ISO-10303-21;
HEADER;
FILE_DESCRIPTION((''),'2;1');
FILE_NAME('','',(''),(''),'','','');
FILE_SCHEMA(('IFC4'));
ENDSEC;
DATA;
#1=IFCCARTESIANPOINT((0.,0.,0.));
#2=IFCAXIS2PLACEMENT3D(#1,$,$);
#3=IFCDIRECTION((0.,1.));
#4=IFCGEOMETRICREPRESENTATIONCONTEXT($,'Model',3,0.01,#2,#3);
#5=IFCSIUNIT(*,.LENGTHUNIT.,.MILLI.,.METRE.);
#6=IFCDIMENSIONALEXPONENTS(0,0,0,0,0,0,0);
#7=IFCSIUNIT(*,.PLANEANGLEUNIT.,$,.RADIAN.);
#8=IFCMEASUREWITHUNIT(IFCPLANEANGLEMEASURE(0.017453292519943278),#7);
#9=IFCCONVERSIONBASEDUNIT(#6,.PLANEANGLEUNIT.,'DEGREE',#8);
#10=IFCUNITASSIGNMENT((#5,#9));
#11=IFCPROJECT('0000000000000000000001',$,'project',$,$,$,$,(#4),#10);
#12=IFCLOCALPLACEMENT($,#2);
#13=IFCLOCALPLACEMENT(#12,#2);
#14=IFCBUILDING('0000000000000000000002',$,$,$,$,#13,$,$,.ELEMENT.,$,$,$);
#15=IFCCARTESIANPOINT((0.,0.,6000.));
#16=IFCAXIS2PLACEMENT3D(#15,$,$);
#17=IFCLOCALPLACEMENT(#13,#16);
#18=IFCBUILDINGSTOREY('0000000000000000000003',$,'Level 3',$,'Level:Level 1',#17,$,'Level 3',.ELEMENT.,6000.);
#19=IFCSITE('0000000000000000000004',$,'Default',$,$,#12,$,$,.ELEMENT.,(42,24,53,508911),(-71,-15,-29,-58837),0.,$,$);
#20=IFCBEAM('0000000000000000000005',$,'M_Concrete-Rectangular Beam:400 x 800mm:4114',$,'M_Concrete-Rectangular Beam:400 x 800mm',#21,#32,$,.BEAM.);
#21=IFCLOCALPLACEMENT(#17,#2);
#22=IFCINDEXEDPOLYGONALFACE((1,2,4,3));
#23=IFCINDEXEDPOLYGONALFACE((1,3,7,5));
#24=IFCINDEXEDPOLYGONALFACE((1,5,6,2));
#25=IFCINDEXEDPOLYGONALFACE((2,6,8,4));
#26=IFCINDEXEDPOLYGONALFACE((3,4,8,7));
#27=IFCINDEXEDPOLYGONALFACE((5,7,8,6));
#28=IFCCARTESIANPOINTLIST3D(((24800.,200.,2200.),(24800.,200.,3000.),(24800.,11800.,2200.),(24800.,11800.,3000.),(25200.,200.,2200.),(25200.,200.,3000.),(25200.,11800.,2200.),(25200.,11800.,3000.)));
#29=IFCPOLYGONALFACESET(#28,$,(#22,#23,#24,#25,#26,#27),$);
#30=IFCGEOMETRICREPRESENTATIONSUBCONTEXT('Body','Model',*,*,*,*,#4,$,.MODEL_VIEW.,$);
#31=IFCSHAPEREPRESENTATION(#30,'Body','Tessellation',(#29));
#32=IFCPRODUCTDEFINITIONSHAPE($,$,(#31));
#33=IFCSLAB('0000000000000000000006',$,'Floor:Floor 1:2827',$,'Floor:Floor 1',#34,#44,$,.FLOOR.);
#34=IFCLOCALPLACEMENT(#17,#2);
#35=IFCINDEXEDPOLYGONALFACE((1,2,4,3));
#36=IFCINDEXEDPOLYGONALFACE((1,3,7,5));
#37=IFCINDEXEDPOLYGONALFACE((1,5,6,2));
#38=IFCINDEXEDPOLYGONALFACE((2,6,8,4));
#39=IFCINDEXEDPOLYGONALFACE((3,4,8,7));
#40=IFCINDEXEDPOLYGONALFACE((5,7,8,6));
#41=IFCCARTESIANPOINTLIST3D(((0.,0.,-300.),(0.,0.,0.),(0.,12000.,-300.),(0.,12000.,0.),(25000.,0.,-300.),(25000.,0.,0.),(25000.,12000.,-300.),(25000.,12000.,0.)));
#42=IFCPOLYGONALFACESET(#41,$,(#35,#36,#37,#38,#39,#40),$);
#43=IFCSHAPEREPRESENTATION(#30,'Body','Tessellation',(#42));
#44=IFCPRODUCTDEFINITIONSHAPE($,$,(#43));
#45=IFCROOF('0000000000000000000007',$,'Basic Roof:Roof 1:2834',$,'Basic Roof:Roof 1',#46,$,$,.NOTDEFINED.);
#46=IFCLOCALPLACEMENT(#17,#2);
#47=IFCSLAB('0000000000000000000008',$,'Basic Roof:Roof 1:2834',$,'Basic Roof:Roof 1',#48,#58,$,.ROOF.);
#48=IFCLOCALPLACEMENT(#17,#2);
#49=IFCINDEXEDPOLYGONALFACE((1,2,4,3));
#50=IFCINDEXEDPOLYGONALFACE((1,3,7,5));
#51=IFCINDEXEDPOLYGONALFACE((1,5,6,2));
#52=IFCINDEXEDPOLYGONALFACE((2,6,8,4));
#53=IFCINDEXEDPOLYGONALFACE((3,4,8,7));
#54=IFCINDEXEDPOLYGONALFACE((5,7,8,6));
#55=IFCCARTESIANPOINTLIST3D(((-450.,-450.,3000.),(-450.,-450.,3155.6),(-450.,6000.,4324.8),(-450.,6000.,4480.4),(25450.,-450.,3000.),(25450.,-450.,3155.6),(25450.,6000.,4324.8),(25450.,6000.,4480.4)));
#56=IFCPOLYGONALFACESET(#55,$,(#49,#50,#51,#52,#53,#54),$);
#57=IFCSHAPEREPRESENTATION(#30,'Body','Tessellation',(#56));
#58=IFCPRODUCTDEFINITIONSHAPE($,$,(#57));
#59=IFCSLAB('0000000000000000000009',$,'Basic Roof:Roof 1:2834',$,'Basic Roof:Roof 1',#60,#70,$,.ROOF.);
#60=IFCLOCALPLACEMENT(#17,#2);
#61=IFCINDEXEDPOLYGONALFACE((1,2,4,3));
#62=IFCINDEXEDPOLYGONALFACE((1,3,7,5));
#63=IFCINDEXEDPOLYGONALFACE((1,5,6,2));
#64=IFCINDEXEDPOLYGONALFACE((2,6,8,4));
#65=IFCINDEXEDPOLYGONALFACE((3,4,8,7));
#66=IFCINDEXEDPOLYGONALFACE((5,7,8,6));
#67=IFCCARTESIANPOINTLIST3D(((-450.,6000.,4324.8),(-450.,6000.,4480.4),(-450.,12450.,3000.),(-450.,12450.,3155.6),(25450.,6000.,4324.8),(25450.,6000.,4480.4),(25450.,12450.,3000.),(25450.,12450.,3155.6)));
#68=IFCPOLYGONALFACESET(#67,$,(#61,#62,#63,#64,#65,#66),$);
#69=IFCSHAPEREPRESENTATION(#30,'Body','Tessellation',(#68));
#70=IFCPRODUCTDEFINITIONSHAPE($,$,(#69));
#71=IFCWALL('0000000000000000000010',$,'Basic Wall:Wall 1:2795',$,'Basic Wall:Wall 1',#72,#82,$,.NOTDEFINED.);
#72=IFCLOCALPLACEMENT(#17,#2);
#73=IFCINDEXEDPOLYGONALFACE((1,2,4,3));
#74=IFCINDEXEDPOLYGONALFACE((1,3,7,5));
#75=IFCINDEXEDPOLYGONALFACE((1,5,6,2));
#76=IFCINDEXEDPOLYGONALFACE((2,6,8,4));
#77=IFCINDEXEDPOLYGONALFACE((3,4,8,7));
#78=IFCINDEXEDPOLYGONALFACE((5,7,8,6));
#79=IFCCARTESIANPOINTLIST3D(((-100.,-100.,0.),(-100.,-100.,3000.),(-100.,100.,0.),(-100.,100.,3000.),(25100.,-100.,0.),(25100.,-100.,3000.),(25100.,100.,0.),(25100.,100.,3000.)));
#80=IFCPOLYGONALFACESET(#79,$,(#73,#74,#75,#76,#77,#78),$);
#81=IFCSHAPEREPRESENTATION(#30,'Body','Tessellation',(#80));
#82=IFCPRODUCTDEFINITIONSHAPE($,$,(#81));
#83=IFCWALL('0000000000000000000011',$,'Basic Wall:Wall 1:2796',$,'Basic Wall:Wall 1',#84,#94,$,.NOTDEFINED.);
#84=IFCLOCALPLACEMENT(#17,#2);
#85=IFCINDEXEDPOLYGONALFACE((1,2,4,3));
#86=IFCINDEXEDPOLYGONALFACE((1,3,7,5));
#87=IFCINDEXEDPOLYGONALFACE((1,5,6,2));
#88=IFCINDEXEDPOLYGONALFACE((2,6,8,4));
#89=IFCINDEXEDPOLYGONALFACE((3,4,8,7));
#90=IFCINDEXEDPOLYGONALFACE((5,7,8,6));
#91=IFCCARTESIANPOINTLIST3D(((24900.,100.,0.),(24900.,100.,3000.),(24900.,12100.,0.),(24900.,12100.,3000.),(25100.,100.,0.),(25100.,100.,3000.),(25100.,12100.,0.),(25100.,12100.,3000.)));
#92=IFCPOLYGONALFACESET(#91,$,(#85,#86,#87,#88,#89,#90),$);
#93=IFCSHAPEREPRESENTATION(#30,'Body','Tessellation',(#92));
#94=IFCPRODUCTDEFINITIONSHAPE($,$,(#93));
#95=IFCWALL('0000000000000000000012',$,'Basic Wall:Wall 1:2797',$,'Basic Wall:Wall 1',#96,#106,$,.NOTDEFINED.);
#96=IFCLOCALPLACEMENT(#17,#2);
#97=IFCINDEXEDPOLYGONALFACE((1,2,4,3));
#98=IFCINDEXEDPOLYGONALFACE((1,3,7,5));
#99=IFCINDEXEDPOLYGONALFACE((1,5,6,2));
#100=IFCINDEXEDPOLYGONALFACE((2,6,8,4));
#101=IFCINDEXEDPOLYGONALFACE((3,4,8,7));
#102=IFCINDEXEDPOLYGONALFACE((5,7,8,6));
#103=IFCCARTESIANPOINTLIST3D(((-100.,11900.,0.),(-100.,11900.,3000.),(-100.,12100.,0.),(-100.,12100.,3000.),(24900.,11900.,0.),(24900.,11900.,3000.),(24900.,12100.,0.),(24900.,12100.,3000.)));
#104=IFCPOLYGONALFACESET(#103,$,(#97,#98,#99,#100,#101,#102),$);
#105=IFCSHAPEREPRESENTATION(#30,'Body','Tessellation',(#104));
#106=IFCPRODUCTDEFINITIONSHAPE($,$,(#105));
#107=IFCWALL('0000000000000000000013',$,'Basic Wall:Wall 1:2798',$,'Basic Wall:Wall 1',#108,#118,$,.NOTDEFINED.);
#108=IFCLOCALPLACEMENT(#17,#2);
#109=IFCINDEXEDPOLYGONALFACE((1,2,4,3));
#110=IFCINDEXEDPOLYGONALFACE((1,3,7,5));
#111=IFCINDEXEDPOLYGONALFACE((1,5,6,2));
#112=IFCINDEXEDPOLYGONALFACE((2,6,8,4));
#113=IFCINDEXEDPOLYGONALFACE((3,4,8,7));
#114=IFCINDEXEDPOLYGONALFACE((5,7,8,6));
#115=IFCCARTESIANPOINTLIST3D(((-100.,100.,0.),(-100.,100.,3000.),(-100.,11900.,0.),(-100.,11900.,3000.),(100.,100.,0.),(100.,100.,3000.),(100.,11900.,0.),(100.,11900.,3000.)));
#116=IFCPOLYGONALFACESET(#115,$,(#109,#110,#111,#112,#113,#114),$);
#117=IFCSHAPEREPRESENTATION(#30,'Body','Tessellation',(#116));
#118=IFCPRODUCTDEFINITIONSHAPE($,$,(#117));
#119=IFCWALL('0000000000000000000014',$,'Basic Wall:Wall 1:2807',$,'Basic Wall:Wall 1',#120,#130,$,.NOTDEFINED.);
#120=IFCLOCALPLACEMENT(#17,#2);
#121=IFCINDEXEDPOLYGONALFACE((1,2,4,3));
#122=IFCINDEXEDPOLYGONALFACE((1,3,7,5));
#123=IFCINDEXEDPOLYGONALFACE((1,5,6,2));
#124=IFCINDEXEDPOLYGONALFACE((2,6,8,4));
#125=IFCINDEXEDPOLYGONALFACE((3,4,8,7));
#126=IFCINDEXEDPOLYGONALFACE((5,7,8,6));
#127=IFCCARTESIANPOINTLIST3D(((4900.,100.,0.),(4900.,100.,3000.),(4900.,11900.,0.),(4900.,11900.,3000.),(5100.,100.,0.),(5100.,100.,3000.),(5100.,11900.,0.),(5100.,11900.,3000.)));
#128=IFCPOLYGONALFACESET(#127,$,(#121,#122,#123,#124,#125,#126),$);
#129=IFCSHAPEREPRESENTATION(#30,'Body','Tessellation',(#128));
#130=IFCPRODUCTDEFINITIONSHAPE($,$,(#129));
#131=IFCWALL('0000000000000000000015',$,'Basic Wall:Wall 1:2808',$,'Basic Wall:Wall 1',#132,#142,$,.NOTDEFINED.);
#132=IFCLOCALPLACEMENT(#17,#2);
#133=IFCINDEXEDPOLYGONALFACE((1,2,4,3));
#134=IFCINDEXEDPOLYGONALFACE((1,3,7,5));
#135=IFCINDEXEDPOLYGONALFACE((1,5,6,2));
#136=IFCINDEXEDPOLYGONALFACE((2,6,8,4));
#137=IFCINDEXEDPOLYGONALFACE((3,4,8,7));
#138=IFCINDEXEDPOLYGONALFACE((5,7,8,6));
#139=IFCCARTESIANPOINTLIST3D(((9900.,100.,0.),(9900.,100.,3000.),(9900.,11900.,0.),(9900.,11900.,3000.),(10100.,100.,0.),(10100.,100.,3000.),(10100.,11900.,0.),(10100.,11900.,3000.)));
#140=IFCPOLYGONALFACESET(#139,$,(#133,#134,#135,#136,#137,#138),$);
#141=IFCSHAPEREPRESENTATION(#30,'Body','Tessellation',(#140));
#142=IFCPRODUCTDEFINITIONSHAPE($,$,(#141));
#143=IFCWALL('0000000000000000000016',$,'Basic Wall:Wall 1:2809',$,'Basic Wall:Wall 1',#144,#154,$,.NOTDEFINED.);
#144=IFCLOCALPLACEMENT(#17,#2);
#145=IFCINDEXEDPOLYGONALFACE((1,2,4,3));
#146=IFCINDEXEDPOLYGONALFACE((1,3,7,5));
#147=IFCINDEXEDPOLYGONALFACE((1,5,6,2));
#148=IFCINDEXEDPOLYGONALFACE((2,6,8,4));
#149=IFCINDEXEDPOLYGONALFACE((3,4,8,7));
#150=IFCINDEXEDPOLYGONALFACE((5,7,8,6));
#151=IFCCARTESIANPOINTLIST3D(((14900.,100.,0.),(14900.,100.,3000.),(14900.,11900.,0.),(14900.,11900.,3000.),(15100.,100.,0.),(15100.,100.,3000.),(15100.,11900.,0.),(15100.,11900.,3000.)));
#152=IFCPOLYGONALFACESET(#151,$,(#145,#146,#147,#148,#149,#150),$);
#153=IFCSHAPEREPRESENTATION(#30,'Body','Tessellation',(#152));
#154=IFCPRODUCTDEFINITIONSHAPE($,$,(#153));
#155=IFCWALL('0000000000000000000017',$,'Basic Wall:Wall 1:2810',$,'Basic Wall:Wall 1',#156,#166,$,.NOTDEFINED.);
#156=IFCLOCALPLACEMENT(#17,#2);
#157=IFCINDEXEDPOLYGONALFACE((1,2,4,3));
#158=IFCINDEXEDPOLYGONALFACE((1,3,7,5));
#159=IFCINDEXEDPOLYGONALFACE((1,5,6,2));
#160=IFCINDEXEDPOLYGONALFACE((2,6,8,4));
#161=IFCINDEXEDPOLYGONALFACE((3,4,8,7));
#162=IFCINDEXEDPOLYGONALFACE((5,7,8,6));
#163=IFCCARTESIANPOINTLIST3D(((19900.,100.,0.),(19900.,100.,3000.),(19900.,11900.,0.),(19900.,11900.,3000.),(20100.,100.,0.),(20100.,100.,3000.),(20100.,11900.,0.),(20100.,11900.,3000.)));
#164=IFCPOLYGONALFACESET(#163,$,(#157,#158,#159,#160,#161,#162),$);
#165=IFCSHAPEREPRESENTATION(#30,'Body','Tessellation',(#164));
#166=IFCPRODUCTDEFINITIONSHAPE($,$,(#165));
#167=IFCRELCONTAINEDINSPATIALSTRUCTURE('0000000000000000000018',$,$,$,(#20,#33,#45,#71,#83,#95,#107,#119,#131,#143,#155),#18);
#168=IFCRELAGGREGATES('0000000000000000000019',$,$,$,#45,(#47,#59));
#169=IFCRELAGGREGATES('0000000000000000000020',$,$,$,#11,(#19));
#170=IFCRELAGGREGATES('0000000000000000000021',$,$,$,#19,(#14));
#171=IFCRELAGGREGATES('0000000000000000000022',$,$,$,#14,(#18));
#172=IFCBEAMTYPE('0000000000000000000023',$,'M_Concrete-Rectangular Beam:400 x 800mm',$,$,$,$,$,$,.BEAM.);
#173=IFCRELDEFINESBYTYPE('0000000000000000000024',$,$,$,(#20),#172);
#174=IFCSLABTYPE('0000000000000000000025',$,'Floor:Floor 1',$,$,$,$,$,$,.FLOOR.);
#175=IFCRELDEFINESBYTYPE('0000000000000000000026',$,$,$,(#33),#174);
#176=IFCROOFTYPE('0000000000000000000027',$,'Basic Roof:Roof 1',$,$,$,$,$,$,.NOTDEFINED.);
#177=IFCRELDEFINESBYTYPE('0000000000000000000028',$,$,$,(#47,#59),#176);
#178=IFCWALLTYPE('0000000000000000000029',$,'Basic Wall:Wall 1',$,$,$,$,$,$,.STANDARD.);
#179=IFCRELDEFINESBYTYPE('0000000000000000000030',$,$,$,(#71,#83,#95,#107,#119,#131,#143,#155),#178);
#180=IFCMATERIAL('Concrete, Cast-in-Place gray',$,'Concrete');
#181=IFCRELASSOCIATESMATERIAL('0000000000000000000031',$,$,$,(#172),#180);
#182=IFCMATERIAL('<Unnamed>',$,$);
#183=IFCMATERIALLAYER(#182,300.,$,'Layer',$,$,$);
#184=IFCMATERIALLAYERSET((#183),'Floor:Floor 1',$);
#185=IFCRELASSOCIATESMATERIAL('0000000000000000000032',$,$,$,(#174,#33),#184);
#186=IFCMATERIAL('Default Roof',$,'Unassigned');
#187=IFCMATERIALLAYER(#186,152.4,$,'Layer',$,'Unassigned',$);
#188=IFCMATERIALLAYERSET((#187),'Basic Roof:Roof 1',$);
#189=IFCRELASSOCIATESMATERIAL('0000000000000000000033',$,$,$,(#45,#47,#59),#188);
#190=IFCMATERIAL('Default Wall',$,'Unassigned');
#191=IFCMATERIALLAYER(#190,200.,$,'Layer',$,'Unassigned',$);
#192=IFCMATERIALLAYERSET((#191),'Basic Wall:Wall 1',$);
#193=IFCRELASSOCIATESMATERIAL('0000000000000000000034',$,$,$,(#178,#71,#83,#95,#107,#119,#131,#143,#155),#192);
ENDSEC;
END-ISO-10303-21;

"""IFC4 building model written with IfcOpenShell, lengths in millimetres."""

from ifc_helpers import new_model, entity, si_unit, converted_unit, direction, frame, frame_2d, origin, origin_2d_with_axis, place, context, subcontext, project, spatial, rectangle, extrude, source, transform, mapped, material, layer, layer_set, layer_usage, material_profile, profile_set, type_object, type_shapes, element, aggregate, save


model = new_model("IFC4")

# Units and contexts
model_context = context("Model", 3, precision=0.01, world=origin(), true_north=direction((0.0, 1.0)))
body_context = subcontext(model_context, "Body", "Model", "MODEL_VIEW")
ifc_project = project(units=[si_unit("LENGTHUNIT", "METRE", prefix="MILLI"), converted_unit("PLANEANGLEUNIT", "DEGREE", entity("IfcPlaneAngleMeasure", 0.017453292519943278), si_unit("PLANEANGLEUNIT", "RADIAN"), dimensions=[0, 0, 0, 0, 0, 0, 0])], contexts=[model_context])

# Site, building, storey
site_placement = place(None, origin())
site = spatial("IfcSite", under=ifc_project, at=site_placement, Name="Default", CompositionType="ELEMENT", RefLatitude=(42, 24, 53, 508911), RefLongitude=(-71, -15, -29, -58837), RefElevation=0.0)
building_placement = place(site_placement, origin())
building = spatial("IfcBuilding", under=site, at=building_placement, CompositionType="ELEMENT")
storey_placement = place(building_placement, frame((0.0, 0.0, 6000.0)))
storey = spatial("IfcBuildingStorey", under=building, at=storey_placement, Name="Level 3", ObjectType="Level:Level 1", LongName="Level 3", CompositionType="ELEMENT", Elevation=6000.0)

# Beam
ifc_material_1 = material(Name="Concrete, Cast-in-Place gray", Category="Concrete")
ifc_material_profile = material_profile(ifc_material_1, rectangle(XDim=800.0, YDim=400.0, at=origin_2d_with_axis()), Name="400 x 800mm")
ifc_profile_set = profile_set([ifc_material_profile], Name="400 x 800mm")
beam_type_1 = type_object("IfcBeamType", Name="M_Concrete-Rectangular Beam:400 x 800mm", PredefinedType="BEAM", material=ifc_profile_set)
shared_shape_1 = source(origin(), body_context, "Body", "SweptSolid", [
    extrude(rectangle(XDim=800.0, YDim=400.0, at=frame_2d((0.0, 0.0), x_axis=(0.0, 1.0))), frame((25000.0, 200.0, 8600.0), z_axis=(0.0, 1.0, 0.0), x_axis=(-1.0, 0.0, 0.0)), (0.0, 0.0, 1.0), 11600.0),
])
type_shapes(beam_type_1, [shared_shape_1])
beam_1_placement = place(storey_placement, frame((0.0, 0.0, -6000.0)))
element("IfcBeam", 1, at=beam_1_placement, inside=storey, type_object=beam_type_1, Name="M_Concrete-Rectangular Beam:400 x 800mm:4114", ObjectType="M_Concrete-Rectangular Beam:400 x 800mm", PredefinedType="BEAM", context=body_context, shape_type="MappedRepresentation", body=[
    mapped(shared_shape_1, transform((0.0, 0.0, 0.0), scale=1.0)),
])

# Slab
ifc_material_2 = material(Name="<Unnamed>")
ifc_layer_1 = layer(ifc_material_2, 300.0, Name="Layer")
ifc_layer_set_1 = layer_set([ifc_layer_1], Name="Floor:Floor 1")
ifc_layer_usage_1 = layer_usage(ifc_layer_set_1, "AXIS3", "POSITIVE", 0.0)
slab_type = type_object("IfcSlabType", Name="Floor:Floor 1", PredefinedType="FLOOR", material=ifc_layer_set_1)
slab_1_placement = place(storey_placement, origin())
element("IfcSlab", 2, at=slab_1_placement, inside=storey, type_object=slab_type, material=ifc_layer_usage_1, Name="Floor:Floor 1:2827", ObjectType="Floor:Floor 1", PredefinedType="FLOOR", context=body_context, shape_type="SweptSolid", body=[
    extrude(rectangle(XDim=12000.0, YDim=25000.0, at=origin_2d_with_axis()), frame((12500.0, 6000.0, 0.0), z_axis=(0.0, 0.0, -1.0), x_axis=(0.0, 1.0, 0.0)), (0.0, 0.0, 1.0), 300.0),
])

# Roof, slabs
ifc_material_3 = material(Name="Default Roof", Category="Unassigned")
ifc_layer_2 = layer(ifc_material_3, 152.4, Name="Layer", Category="Unassigned")
ifc_layer_set_2 = layer_set([ifc_layer_2], Name="Basic Roof:Roof 1")
roof_placement = place(storey_placement, frame((-450.0, -450.0, 3000.0)))
roof = element("IfcRoof", 3, at=roof_placement, inside=storey, material=ifc_layer_set_2, Name="Basic Roof:Roof 1:2834", ObjectType="Basic Roof:Roof 1", PredefinedType="NOTDEFINED")
roof_type = type_object("IfcRoofType", Name="Basic Roof:Roof 1", PredefinedType="NOTDEFINED")
slab_2_placement = place(roof_placement, origin())
slab_2 = element("IfcSlab", 4, at=slab_2_placement, type_object=roof_type, material=ifc_layer_set_2, Name="Basic Roof:Roof 1:2834", ObjectType="Basic Roof:Roof 1", PredefinedType="ROOF", context=body_context, shape_type="SweptSolid", body=[
    extrude(rectangle(XDim=25900.0, YDim=6584.6, at=frame_2d((0.0, 0.0), x_axis=(-1.0, 0.0))), frame((12950.0, 3225.0, 662.4), z_axis=(0.0, -0.201195, 0.979551), x_axis=(1.0, 0.0, 0.0)), (0.0, 0.201195, 0.979551), 155.6),
])
slab_3_placement = place(roof_placement, origin())
slab_3 = element("IfcSlab", 5, at=slab_3_placement, type_object=roof_type, material=ifc_layer_set_2, Name="Basic Roof:Roof 1:2834", ObjectType="Basic Roof:Roof 1", PredefinedType="ROOF", context=body_context, shape_type="SweptSolid", body=[
    extrude(rectangle(XDim=6584.6, YDim=25900.0, at=frame_2d((0.0, 0.0), x_axis=(0.0, -1.0))), frame((12950.0, 9675.0, 662.4), z_axis=(0.0, 0.201195, 0.979551), x_axis=(1.0, 0.0, 0.0)), (0.0, -0.201195, 0.979551), 155.6),
])
aggregate(roof, [slab_2, slab_3])

# Walls
ifc_material_4 = material(Name="Default Wall", Category="Unassigned")
ifc_layer_3 = layer(ifc_material_4, 200.0, Name="Layer", Category="Unassigned")
ifc_layer_set_3 = layer_set([ifc_layer_3], Name="Basic Wall:Wall 1")
ifc_layer_usage_2 = layer_usage(ifc_layer_set_3, "AXIS2", "NEGATIVE", 100.0)
wall_type = type_object("IfcWallType", Name="Basic Wall:Wall 1", PredefinedType="STANDARD", material=ifc_layer_set_3)
wall_1_placement = place(storey_placement, frame((-100.0, 0.0, 0.0)))
element("IfcWall", 6, at=wall_1_placement, inside=storey, type_object=wall_type, material=ifc_layer_usage_2, Name="Basic Wall:Wall 1:2795", ObjectType="Basic Wall:Wall 1", PredefinedType="NOTDEFINED", context=body_context, shape_type="SweptSolid", body=[
    extrude(rectangle(XDim=25200.0, YDim=200.0, at=frame_2d((12600.0, 0.0), x_axis=(-1.0, 0.0))), origin(), (0.0, 0.0, 1.0), 3000.0),
])
ifc_layer_usage_3 = layer_usage(ifc_layer_set_3, "AXIS2", "NEGATIVE", 100.0)
wall_2_placement = place(storey_placement, frame((25000.0, 100.0, 0.0), z_axis=(0.0, 0.0, 1.0), x_axis=(0.0, 1.0, 0.0)))
element("IfcWall", 7, at=wall_2_placement, inside=storey, type_object=wall_type, material=ifc_layer_usage_3, Name="Basic Wall:Wall 1:2796", ObjectType="Basic Wall:Wall 1", PredefinedType="NOTDEFINED", context=body_context, shape_type="SweptSolid", body=[
    extrude(rectangle(XDim=12000.0, YDim=200.0, at=frame_2d((6000.0, 0.0), x_axis=(-1.0, 0.0))), origin(), (0.0, 0.0, 1.0), 3000.0),
])
ifc_layer_usage_4 = layer_usage(ifc_layer_set_3, "AXIS2", "NEGATIVE", 100.0)
wall_3_placement = place(storey_placement, frame((24900.0, 12000.0, 0.0), z_axis=(0.0, 0.0, 1.0), x_axis=(-1.0, 0.0, 0.0)))
element("IfcWall", 8, at=wall_3_placement, inside=storey, type_object=wall_type, material=ifc_layer_usage_4, Name="Basic Wall:Wall 1:2797", ObjectType="Basic Wall:Wall 1", PredefinedType="NOTDEFINED", context=body_context, shape_type="SweptSolid", body=[
    extrude(rectangle(XDim=25000.0, YDim=200.0, at=frame_2d((12500.0, 0.0), x_axis=(-1.0, 0.0))), origin(), (0.0, 0.0, 1.0), 3000.0),
])
ifc_layer_usage_5 = layer_usage(ifc_layer_set_3, "AXIS2", "NEGATIVE", 100.0)
wall_4_placement = place(storey_placement, frame((0.0, 11900.0, 0.0), z_axis=(0.0, 0.0, 1.0), x_axis=(0.0, -1.0, 0.0)))
element("IfcWall", 9, at=wall_4_placement, inside=storey, type_object=wall_type, material=ifc_layer_usage_5, Name="Basic Wall:Wall 1:2798", ObjectType="Basic Wall:Wall 1", PredefinedType="NOTDEFINED", context=body_context, shape_type="SweptSolid", body=[
    extrude(rectangle(XDim=11800.0, YDim=200.0, at=frame_2d((5900.0, 0.0), x_axis=(-1.0, 0.0))), origin(), (0.0, 0.0, 1.0), 3000.0),
])
ifc_layer_usage_6 = layer_usage(ifc_layer_set_3, "AXIS2", "NEGATIVE", 100.0)
wall_5_placement = place(storey_placement, frame((5000.0, 100.0, 0.0), z_axis=(0.0, 0.0, 1.0), x_axis=(0.0, 1.0, 0.0)))
element("IfcWall", 10, at=wall_5_placement, inside=storey, type_object=wall_type, material=ifc_layer_usage_6, Name="Basic Wall:Wall 1:2807", ObjectType="Basic Wall:Wall 1", PredefinedType="NOTDEFINED", context=body_context, shape_type="SweptSolid", body=[
    extrude(rectangle(XDim=11800.0, YDim=200.0, at=frame_2d((5900.0, 0.0), x_axis=(-1.0, 0.0))), origin(), (0.0, 0.0, 1.0), 3000.0),
])
ifc_layer_usage_7 = layer_usage(ifc_layer_set_3, "AXIS2", "NEGATIVE", 100.0)
wall_6_placement = place(storey_placement, frame((10000.0, 100.0, 0.0), z_axis=(0.0, 0.0, 1.0), x_axis=(0.0, 1.0, 0.0)))
element("IfcWall", 11, at=wall_6_placement, inside=storey, type_object=wall_type, material=ifc_layer_usage_7, Name="Basic Wall:Wall 1:2808", ObjectType="Basic Wall:Wall 1", PredefinedType="NOTDEFINED", context=body_context, shape_type="SweptSolid", body=[
    extrude(rectangle(XDim=11800.0, YDim=200.0, at=frame_2d((5900.0, 0.0), x_axis=(-1.0, 0.0))), origin(), (0.0, 0.0, 1.0), 3000.0),
])
ifc_layer_usage_8 = layer_usage(ifc_layer_set_3, "AXIS2", "NEGATIVE", 100.0)
wall_7_placement = place(storey_placement, frame((15000.0, 100.0, 0.0), z_axis=(0.0, 0.0, 1.0), x_axis=(0.0, 1.0, 0.0)))
element("IfcWall", 12, at=wall_7_placement, inside=storey, type_object=wall_type, material=ifc_layer_usage_8, Name="Basic Wall:Wall 1:2809", ObjectType="Basic Wall:Wall 1", PredefinedType="NOTDEFINED", context=body_context, shape_type="SweptSolid", body=[
    extrude(rectangle(XDim=11800.0, YDim=200.0, at=frame_2d((5900.0, 0.0), x_axis=(-1.0, 0.0))), origin(), (0.0, 0.0, 1.0), 3000.0),
])
ifc_layer_usage_9 = layer_usage(ifc_layer_set_3, "AXIS2", "NEGATIVE", 100.0)
wall_8_placement = place(storey_placement, frame((20000.0, 100.0, 0.0), z_axis=(0.0, 0.0, 1.0), x_axis=(0.0, 1.0, 0.0)))
element("IfcWall", 13, at=wall_8_placement, inside=storey, type_object=wall_type, material=ifc_layer_usage_9, Name="Basic Wall:Wall 1:2810", ObjectType="Basic Wall:Wall 1", PredefinedType="NOTDEFINED", context=body_context, shape_type="SweptSolid", body=[
    extrude(rectangle(XDim=11800.0, YDim=200.0, at=frame_2d((5900.0, 0.0), x_axis=(-1.0, 0.0))), origin(), (0.0, 0.0, 1.0), 3000.0),
])

save(model, "model.ifc")
